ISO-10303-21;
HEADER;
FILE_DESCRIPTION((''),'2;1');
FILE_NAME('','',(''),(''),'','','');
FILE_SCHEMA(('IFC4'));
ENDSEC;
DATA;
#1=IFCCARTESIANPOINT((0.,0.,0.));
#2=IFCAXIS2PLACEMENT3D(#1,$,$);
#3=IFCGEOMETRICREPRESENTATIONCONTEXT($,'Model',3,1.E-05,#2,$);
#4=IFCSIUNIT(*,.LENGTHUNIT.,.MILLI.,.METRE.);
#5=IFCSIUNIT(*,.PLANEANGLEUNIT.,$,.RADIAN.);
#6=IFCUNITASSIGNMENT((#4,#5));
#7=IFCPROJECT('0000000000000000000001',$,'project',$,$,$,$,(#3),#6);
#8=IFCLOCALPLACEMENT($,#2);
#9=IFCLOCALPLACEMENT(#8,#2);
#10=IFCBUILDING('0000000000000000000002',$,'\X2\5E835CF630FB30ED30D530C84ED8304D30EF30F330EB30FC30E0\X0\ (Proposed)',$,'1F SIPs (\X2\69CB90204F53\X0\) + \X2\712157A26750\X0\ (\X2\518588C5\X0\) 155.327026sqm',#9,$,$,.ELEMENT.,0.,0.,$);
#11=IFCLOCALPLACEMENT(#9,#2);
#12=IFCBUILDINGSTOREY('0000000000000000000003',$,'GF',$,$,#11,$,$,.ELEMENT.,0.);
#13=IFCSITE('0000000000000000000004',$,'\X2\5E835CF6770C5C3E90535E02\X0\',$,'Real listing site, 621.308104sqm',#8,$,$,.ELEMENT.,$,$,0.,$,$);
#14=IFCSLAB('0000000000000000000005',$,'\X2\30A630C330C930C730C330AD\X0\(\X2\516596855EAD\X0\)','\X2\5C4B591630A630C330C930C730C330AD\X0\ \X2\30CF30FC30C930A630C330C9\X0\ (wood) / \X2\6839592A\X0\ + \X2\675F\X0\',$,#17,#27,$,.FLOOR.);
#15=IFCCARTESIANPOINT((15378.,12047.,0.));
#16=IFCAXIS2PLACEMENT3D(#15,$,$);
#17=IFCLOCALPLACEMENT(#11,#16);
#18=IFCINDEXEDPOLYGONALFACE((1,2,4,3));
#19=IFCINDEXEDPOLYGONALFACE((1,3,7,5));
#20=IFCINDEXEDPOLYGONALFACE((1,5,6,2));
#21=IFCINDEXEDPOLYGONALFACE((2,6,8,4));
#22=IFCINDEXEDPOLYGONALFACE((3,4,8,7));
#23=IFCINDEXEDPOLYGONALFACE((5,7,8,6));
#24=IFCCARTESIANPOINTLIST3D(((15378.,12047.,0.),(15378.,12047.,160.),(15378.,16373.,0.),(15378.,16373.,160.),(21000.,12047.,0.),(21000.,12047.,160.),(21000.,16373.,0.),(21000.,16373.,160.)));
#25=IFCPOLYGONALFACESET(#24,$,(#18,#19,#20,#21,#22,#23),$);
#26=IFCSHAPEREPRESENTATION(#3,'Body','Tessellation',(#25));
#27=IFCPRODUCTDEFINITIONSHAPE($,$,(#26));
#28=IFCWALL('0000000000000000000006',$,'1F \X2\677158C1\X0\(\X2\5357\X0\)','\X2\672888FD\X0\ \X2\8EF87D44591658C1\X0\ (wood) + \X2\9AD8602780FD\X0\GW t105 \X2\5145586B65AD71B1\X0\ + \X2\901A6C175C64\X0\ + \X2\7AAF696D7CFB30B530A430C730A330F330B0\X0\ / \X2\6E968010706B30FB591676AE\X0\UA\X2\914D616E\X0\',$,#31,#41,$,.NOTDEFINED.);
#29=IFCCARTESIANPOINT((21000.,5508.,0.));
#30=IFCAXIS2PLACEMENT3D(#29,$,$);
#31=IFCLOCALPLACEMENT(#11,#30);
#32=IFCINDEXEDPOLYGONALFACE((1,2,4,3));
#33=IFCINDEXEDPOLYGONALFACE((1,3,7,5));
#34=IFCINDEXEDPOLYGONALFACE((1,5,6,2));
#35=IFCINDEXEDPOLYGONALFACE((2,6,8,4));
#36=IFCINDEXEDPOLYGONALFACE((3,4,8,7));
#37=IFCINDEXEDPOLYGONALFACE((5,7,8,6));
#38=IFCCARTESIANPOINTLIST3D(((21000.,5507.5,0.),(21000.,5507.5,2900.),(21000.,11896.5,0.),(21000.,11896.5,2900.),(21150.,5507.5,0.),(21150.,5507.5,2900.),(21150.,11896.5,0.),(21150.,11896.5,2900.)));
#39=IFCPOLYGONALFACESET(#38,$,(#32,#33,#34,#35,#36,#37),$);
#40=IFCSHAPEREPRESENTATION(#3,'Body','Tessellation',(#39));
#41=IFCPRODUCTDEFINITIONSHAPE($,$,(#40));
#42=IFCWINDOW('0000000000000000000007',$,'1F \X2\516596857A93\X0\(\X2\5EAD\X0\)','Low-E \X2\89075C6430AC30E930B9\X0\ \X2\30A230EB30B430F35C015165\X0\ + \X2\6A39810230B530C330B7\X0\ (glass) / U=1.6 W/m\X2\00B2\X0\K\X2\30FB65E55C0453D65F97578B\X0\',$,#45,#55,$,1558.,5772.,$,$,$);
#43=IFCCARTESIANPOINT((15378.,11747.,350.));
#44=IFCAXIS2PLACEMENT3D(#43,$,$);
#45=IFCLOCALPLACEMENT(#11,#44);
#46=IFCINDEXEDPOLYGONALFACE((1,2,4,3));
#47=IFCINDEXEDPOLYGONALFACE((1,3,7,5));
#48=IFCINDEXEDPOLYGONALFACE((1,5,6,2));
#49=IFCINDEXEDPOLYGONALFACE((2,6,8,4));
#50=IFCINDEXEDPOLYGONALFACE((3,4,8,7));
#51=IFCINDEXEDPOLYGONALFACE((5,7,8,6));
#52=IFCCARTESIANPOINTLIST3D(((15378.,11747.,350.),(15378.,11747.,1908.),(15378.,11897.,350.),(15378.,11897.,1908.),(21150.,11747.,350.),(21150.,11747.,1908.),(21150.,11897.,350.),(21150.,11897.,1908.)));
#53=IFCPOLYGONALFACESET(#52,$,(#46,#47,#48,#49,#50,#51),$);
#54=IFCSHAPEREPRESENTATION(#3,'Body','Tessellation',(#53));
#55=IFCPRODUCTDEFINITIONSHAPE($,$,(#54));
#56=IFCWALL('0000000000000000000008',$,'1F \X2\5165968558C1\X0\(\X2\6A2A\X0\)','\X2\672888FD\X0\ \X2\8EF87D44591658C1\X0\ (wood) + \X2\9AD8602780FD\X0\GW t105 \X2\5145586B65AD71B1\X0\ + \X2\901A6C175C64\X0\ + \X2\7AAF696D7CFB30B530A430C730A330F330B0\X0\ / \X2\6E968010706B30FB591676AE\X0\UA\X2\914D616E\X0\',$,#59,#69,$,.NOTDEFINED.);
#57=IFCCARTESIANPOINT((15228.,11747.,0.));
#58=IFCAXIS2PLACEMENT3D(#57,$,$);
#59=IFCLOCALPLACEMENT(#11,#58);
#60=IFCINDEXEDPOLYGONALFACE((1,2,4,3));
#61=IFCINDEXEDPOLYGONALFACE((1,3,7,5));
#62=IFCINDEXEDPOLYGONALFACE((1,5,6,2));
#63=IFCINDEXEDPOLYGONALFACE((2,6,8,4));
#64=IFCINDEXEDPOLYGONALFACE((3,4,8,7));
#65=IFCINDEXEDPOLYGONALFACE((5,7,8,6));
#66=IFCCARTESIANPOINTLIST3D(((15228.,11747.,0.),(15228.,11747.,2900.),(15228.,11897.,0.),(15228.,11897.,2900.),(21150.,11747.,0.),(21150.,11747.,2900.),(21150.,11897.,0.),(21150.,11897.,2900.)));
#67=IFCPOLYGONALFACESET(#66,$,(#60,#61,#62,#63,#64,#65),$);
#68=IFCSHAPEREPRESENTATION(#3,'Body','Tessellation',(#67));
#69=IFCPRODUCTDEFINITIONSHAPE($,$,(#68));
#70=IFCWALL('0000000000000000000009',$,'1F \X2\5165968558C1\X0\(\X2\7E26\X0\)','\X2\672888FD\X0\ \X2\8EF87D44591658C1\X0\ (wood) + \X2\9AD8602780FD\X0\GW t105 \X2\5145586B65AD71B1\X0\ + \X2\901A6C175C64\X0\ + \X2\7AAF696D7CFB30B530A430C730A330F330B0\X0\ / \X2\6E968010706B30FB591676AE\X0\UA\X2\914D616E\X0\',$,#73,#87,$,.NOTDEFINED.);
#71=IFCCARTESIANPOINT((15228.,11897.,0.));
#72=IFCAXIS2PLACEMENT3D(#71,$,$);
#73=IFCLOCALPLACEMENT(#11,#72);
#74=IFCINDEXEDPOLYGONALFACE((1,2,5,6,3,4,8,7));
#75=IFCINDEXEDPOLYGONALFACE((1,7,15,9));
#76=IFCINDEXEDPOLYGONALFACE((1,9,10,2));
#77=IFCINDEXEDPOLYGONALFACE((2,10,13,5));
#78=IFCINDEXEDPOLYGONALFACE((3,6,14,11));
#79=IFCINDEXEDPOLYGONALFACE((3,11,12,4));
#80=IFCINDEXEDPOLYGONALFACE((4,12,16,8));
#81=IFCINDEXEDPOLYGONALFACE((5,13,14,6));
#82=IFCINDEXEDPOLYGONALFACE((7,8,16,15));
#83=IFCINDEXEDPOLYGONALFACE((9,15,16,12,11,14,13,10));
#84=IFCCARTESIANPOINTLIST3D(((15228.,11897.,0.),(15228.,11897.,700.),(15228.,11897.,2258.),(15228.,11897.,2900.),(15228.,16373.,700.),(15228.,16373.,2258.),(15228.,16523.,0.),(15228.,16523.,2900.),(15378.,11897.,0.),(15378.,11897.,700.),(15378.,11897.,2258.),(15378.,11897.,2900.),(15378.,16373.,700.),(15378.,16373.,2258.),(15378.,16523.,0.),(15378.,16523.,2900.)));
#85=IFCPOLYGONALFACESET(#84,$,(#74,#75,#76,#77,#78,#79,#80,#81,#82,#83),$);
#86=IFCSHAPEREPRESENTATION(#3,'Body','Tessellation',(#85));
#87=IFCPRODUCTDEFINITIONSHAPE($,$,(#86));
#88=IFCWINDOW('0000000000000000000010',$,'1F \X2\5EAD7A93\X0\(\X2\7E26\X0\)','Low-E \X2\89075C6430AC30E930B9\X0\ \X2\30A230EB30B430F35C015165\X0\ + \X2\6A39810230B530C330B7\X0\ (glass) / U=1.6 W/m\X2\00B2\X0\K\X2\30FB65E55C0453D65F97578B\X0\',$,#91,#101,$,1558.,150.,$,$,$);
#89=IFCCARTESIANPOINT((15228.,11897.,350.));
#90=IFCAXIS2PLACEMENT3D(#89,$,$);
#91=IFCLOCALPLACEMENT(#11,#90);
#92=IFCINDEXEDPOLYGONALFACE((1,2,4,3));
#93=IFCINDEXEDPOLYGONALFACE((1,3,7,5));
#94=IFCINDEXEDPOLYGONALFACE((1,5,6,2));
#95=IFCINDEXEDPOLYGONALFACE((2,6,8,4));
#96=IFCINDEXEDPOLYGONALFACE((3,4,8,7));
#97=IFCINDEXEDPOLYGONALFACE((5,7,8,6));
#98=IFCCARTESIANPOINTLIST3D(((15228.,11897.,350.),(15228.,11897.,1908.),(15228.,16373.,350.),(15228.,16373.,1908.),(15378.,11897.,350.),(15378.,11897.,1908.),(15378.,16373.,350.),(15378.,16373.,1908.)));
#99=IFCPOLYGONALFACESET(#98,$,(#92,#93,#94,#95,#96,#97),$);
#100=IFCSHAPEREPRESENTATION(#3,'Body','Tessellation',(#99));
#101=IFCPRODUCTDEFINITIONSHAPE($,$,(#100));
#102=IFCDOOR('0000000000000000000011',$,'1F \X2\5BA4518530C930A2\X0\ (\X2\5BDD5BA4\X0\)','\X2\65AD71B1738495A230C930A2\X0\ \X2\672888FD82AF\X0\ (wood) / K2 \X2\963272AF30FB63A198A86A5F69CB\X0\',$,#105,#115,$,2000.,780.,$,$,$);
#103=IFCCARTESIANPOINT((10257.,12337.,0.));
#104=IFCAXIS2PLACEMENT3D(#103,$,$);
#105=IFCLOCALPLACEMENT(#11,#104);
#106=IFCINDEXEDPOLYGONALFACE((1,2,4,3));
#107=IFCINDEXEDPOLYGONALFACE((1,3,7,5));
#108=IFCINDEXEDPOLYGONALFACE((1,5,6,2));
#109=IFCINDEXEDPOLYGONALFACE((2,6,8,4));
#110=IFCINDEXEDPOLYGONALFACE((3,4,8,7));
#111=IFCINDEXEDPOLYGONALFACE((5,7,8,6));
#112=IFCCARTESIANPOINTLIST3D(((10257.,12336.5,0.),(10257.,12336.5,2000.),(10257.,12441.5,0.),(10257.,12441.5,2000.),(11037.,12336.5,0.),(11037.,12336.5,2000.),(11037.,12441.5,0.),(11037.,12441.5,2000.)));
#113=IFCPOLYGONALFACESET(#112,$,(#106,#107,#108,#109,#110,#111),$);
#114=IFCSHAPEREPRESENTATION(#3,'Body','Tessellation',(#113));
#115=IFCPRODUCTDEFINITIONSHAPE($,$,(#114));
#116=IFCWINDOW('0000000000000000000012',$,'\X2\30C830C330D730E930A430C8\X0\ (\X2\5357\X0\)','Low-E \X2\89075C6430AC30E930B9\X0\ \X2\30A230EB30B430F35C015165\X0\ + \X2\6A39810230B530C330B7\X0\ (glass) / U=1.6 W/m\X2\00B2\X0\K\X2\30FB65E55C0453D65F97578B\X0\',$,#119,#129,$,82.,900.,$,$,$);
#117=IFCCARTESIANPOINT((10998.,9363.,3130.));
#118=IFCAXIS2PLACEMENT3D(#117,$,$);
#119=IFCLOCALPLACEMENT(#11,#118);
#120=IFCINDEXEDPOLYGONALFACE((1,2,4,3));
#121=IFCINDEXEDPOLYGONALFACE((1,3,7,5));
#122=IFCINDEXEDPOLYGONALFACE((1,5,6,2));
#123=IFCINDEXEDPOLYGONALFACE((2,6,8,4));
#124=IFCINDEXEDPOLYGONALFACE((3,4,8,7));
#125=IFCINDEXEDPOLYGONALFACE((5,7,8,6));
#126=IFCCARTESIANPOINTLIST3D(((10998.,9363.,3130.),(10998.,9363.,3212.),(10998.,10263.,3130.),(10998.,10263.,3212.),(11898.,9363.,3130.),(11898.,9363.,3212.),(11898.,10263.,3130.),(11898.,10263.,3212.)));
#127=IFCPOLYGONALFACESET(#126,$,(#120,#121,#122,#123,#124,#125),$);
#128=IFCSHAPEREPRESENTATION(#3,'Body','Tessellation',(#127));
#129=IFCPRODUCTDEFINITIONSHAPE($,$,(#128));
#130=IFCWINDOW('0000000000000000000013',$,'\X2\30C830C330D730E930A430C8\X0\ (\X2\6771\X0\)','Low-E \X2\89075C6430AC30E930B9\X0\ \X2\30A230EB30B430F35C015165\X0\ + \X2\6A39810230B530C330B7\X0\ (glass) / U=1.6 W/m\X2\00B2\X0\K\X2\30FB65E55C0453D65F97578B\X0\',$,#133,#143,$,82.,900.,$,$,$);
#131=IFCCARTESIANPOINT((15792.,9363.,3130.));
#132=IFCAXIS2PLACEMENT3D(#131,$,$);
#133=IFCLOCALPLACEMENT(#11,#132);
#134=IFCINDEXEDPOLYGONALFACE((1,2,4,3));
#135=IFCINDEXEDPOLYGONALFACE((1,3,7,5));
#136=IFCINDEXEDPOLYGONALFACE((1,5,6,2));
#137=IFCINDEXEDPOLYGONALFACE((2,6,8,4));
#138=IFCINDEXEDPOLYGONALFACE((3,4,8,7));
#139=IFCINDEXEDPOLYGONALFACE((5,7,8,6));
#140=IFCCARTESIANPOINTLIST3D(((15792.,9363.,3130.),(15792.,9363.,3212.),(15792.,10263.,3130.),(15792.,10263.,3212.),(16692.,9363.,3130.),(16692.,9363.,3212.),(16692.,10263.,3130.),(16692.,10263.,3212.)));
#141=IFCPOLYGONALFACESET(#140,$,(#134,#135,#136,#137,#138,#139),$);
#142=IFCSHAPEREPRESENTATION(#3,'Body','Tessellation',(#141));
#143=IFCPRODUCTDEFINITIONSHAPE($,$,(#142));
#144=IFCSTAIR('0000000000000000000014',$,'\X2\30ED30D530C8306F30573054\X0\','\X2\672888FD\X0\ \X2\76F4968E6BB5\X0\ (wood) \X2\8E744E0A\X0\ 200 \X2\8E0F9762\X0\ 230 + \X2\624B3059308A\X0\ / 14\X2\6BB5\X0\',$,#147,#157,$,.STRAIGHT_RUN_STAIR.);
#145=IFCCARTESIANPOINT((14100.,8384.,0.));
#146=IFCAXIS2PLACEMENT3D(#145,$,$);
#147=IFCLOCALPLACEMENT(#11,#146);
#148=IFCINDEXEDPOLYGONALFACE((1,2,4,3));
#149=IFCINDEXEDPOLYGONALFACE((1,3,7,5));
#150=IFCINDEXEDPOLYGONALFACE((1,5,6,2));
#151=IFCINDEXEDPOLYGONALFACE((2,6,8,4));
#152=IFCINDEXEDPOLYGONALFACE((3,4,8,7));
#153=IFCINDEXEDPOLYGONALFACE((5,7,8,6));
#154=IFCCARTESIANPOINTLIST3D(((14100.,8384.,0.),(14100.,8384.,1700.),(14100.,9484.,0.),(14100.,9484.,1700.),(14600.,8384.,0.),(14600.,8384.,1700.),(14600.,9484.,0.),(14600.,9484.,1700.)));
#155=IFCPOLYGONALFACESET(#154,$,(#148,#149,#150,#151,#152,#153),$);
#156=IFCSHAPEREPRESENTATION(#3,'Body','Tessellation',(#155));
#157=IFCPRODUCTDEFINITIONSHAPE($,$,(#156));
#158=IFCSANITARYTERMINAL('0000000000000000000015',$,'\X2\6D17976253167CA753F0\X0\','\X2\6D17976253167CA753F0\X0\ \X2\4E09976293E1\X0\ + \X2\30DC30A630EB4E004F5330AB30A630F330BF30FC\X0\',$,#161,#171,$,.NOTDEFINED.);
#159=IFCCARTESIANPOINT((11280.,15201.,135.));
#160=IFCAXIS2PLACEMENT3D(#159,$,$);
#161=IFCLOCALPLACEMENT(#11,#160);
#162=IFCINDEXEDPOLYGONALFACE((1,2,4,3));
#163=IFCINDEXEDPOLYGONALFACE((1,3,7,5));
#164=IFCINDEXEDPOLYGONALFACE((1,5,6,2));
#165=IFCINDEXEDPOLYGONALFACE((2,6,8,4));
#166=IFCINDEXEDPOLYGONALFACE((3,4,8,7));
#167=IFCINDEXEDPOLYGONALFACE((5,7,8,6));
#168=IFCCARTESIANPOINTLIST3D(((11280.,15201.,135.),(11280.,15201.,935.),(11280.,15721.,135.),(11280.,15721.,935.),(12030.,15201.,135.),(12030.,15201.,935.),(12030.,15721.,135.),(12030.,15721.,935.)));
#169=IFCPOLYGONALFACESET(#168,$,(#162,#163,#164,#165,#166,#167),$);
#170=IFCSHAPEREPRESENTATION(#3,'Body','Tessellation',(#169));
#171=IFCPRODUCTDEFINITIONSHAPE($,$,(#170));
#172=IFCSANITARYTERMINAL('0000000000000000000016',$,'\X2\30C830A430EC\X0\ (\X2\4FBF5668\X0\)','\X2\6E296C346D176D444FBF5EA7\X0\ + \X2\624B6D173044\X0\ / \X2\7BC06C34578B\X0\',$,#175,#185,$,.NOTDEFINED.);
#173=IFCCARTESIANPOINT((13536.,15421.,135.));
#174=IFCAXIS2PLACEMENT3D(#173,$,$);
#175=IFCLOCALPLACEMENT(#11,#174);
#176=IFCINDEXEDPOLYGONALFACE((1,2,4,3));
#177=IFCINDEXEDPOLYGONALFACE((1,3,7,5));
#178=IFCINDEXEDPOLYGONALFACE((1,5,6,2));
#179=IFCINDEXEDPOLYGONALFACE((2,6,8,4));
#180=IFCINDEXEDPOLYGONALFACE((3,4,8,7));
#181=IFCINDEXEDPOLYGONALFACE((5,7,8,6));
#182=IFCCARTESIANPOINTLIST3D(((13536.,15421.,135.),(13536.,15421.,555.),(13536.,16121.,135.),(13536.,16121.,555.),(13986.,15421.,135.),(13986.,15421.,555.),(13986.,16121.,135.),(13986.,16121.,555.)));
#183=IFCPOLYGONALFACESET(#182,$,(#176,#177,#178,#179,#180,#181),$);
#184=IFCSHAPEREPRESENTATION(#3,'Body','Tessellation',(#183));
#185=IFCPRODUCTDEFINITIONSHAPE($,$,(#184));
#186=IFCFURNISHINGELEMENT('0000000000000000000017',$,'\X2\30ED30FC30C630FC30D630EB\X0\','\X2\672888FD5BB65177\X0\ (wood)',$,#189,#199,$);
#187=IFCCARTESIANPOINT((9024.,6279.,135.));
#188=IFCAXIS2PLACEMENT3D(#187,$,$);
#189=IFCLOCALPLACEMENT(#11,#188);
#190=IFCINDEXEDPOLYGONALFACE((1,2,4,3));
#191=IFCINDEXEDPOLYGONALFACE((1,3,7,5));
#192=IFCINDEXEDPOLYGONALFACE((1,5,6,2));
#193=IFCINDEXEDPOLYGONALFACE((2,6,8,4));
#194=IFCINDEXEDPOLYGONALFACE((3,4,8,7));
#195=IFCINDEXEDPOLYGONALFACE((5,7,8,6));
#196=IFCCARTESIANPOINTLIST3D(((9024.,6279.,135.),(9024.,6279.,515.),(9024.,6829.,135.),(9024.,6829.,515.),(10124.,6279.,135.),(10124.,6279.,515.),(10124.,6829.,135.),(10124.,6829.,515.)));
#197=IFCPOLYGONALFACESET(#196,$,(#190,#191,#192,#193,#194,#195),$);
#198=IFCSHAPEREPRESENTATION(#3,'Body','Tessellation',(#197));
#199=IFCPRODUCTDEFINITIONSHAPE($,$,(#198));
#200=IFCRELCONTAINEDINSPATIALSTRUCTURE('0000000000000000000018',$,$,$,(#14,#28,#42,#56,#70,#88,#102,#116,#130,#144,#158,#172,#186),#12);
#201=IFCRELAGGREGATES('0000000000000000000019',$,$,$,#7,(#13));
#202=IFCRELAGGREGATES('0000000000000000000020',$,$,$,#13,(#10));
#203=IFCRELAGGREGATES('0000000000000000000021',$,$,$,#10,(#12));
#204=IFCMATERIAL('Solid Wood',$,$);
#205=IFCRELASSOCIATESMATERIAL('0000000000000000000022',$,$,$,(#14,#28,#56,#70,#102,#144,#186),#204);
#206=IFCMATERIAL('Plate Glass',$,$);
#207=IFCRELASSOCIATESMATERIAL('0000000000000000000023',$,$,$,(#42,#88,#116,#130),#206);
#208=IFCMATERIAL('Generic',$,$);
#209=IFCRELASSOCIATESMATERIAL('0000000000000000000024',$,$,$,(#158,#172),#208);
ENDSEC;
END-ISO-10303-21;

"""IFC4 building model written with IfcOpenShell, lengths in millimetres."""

from ifc_helpers import new_model, si_unit, frame, frame_2d, origin, place, context, project, spatial, rectangle, extrude, material, element, fill, save


model = new_model("IFC4")

# Units and contexts
model_context = context("Model", 3, precision=1e-05, world=origin())
ifc_project = project(units=[si_unit("LENGTHUNIT", "METRE", prefix="MILLI"), si_unit("PLANEANGLEUNIT", "RADIAN")], contexts=[model_context])

# Site, building, storey
site_placement = place(None, origin())
site = spatial("IfcSite", under=ifc_project, at=site_placement, Name="広島県尾道市", ObjectType="Real listing site, 621.308104sqm", CompositionType="ELEMENT", RefElevation=0.0)
building_placement = place(site_placement, origin())
building = spatial("IfcBuilding", under=site, at=building_placement, Name="広島・ロフト付きワンルーム (Proposed)", ObjectType="1F SIPs (構造体) + 無垢材 (内装) 155.327026sqm", CompositionType="ELEMENT", ElevationOfRefHeight=0.0, ElevationOfTerrain=0.0)
storey_placement = place(building_placement, origin())
storey = spatial("IfcBuildingStorey", under=building, at=storey_placement, Name="GF", CompositionType="ELEMENT", Elevation=0.0)

# Slab
ifc_material_1 = material(Name="Solid Wood")
slab_placement = place(storey_placement, frame((15378.0, 12047.0, 0.0)))
element("IfcSlab", 1, at=slab_placement, inside=storey, material=ifc_material_1, Name="ウッドデッキ(入隅庭)", Description="屋外ウッドデッキ ハードウッド (wood) / 根太 + 束", PredefinedType="FLOOR", context=model_context, shape_type="SweptSolid", body=[
    extrude(rectangle(XDim=5622.0, YDim=4326.0, at=frame_2d((2811.0, 2163.0))), frame((15378.0, 12047.0, 0.0)), (0.0, 0.0, 1.0), 160.0),
])

# Wall, opening, window
wall_1_placement = place(storey_placement, frame((21000.0, 5508.0, 0.0)))
wall_1 = element("IfcWall", 2, at=wall_1_placement, inside=storey, material=ifc_material_1, Name="1F 東壁(南)", Description="木製 軸組外壁 (wood) + 高性能GW t105 充填断熱 + 通気層 + 窯業系サイディング / 準耐火・外皮UA配慮", PredefinedType="NOTDEFINED", context=model_context, shape_type="SweptSolid", body=[
    extrude(rectangle(XDim=150.0, YDim=6389.0, at=frame_2d((75.0, 3194.0))), frame((21000.0, 5508.0, 0.0)), (0.0, 0.0, 1.0), 2900.0),
])
opening_1_placement = place(storey_placement, frame((15378.0, 11747.0, 350.0)))
opening_1 = element("IfcOpeningElement", 3, at=opening_1_placement, cuts=wall_1, PredefinedType="NOTDEFINED", context=model_context, shape_type="SweptSolid", body=[
    extrude(rectangle(XDim=5772.0, YDim=150.0, at=frame_2d((2886.0, 75.0))), frame((15378.0, 11747.0, 350.0)), (0.0, 0.0, 1.0), 1558.0),
])
ifc_material_2 = material(Name="Plate Glass")
window_1_placement = place(storey_placement, frame((15378.0, 11747.0, 350.0)))
window_1 = element("IfcWindow", 4, at=window_1_placement, inside=storey, material=ifc_material_2, Name="1F 入隅窓(庭)", Description="Low-E 複層ガラス アルゴン封入 + 樹脂サッシ (glass) / U=1.6 W/m²K・日射取得型", OverallHeight=1558.0, OverallWidth=5772.0, context=model_context, shape_type="SweptSolid", body=[
    extrude(rectangle(XDim=5772.0, YDim=150.0, at=frame_2d((2886.0, 75.0))), frame((15378.0, 11747.0, 350.0)), (0.0, 0.0, 1.0), 1558.0),
])
fill(opening_1, window_1)

# Wall
wall_2_placement = place(storey_placement, frame((15228.0, 11747.0, 0.0)))
element("IfcWall", 5, at=wall_2_placement, inside=storey, material=ifc_material_1, Name="1F 入隅壁(横)", Description="木製 軸組外壁 (wood) + 高性能GW t105 充填断熱 + 通気層 + 窯業系サイディング / 準耐火・外皮UA配慮", PredefinedType="NOTDEFINED", context=model_context, shape_type="SweptSolid", body=[
    extrude(rectangle(XDim=5922.0, YDim=150.0, at=frame_2d((2961.0, 75.0))), frame((15228.0, 11747.0, 0.0)), (0.0, 0.0, 1.0), 2900.0),
])

# Wall, opening, window
wall_3_placement = place(storey_placement, frame((15228.0, 11897.0, 0.0)))
wall_3 = element("IfcWall", 6, at=wall_3_placement, inside=storey, material=ifc_material_1, Name="1F 入隅壁(縦)", Description="木製 軸組外壁 (wood) + 高性能GW t105 充填断熱 + 通気層 + 窯業系サイディング / 準耐火・外皮UA配慮", PredefinedType="NOTDEFINED", context=model_context, shape_type="SweptSolid", body=[
    extrude(rectangle(XDim=150.0, YDim=4626.0, at=frame_2d((75.0, 2313.0))), frame((15228.0, 11897.0, 0.0)), (0.0, 0.0, 1.0), 2900.0),
])
opening_2_placement = place(storey_placement, frame((15228.0, 11897.0, 350.0)))
opening_2 = element("IfcOpeningElement", 7, at=opening_2_placement, cuts=wall_3, PredefinedType="NOTDEFINED", context=model_context, shape_type="SweptSolid", body=[
    extrude(rectangle(XDim=150.0, YDim=4476.0, at=frame_2d((75.0, 2238.0))), frame((15228.0, 11897.0, 350.0)), (0.0, 0.0, 1.0), 1558.0),
])
window_2_placement = place(storey_placement, frame((15228.0, 11897.0, 350.0)))
window_2 = element("IfcWindow", 8, at=window_2_placement, inside=storey, material=ifc_material_2, Name="1F 庭窓(縦)", Description="Low-E 複層ガラス アルゴン封入 + 樹脂サッシ (glass) / U=1.6 W/m²K・日射取得型", OverallHeight=1558.0, OverallWidth=150.0, context=model_context, shape_type="SweptSolid", body=[
    extrude(rectangle(XDim=150.0, YDim=4476.0, at=frame_2d((75.0, 2238.0))), frame((15228.0, 11897.0, 350.0)), (0.0, 0.0, 1.0), 1558.0),
])
fill(opening_2, window_2)

# Door
door_placement = place(storey_placement, frame((10257.0, 12337.0, 0.0)))
element("IfcDoor", 9, at=door_placement, inside=storey, material=ifc_material_1, Name="1F 室内ドア (寝室)", Description="断熱玄関ドア 木製芯 (wood) / K2 防犯・採風機構", OverallHeight=2000.0, OverallWidth=780.0, context=model_context, shape_type="SweptSolid", body=[
    extrude(rectangle(XDim=780.0, YDim=105.0, at=frame_2d((390.0, 52.0))), frame((10257.0, 12337.0, 0.0)), (0.0, 0.0, 1.0), 2000.0),
])

# Windows
window_3_placement = place(storey_placement, frame((10998.0, 9363.0, 3130.0)))
element("IfcWindow", 10, at=window_3_placement, inside=storey, material=ifc_material_2, Name="トップライト (南)", Description="Low-E 複層ガラス アルゴン封入 + 樹脂サッシ (glass) / U=1.6 W/m²K・日射取得型", OverallHeight=82.0, OverallWidth=900.0, context=model_context, shape_type="SweptSolid", body=[
    extrude(rectangle(XDim=900.0, YDim=900.0, at=frame_2d((450.0, 450.0))), frame((10998.0, 9363.0, 3130.0)), (0.0, 0.0, 1.0), 82.0),
])
window_4_placement = place(storey_placement, frame((15792.0, 9363.0, 3130.0)))
element("IfcWindow", 11, at=window_4_placement, inside=storey, material=ifc_material_2, Name="トップライト (東)", Description="Low-E 複層ガラス アルゴン封入 + 樹脂サッシ (glass) / U=1.6 W/m²K・日射取得型", OverallHeight=82.0, OverallWidth=900.0, context=model_context, shape_type="SweptSolid", body=[
    extrude(rectangle(XDim=900.0, YDim=900.0, at=frame_2d((450.0, 450.0))), frame((15792.0, 9363.0, 3130.0)), (0.0, 0.0, 1.0), 82.0),
])

# Stair
stair_placement = place(storey_placement, frame((14100.0, 8384.0, 0.0)))
element("IfcStair", 12, at=stair_placement, inside=storey, material=ifc_material_1, Name="ロフトはしご", Description="木製 直階段 (wood) 蹴上 200 踏面 230 + 手すり / 14段", PredefinedType="STRAIGHT_RUN_STAIR", context=model_context, shape_type="SweptSolid", body=[
    extrude(rectangle(XDim=500.0, YDim=1100.0, at=frame_2d((250.0, 550.0))), frame((14100.0, 8384.0, 0.0)), (0.0, 0.0, 1.0), 1700.0),
])

# Sanitary terminals
ifc_material_3 = material(Name="Generic")
sanitary_terminal_1_placement = place(storey_placement, frame((11280.0, 15201.0, 135.0)))
element("IfcSanitaryTerminal", 13, at=sanitary_terminal_1_placement, inside=storey, material=ifc_material_3, Name="洗面化粧台", Description="洗面化粧台 三面鏡 + ボウル一体カウンター", PredefinedType="NOTDEFINED", context=model_context, shape_type="SweptSolid", body=[
    extrude(rectangle(XDim=750.0, YDim=520.0, at=frame_2d((375.0, 260.0))), frame((11280.0, 15201.0, 135.0)), (0.0, 0.0, 1.0), 800.0),
])
sanitary_terminal_2_placement = place(storey_placement, frame((13536.0, 15421.0, 135.0)))
element("IfcSanitaryTerminal", 14, at=sanitary_terminal_2_placement, inside=storey, material=ifc_material_3, Name="トイレ (便器)", Description="温水洗浄便座 + 手洗い / 節水型", PredefinedType="NOTDEFINED", context=model_context, shape_type="SweptSolid", body=[
    extrude(rectangle(XDim=450.0, YDim=700.0, at=frame_2d((225.0, 350.0))), frame((13536.0, 15421.0, 135.0)), (0.0, 0.0, 1.0), 420.0),
])

# Furnishing element
furnishing_1_placement = place(storey_placement, frame((9024.0, 6279.0, 135.0)))
element("IfcFurnishingElement", 15, at=furnishing_1_placement, inside=storey, material=ifc_material_1, Name="ローテーブル", Description="木製家具 (wood)", context=model_context, shape_type="SweptSolid", body=[
    extrude(rectangle(XDim=1100.0, YDim=550.0, at=frame_2d((550.0, 275.0))), frame((9024.0, 6279.0, 135.0)), (0.0, 0.0, 1.0), 380.0),
])

save(model, "model.ifc")
